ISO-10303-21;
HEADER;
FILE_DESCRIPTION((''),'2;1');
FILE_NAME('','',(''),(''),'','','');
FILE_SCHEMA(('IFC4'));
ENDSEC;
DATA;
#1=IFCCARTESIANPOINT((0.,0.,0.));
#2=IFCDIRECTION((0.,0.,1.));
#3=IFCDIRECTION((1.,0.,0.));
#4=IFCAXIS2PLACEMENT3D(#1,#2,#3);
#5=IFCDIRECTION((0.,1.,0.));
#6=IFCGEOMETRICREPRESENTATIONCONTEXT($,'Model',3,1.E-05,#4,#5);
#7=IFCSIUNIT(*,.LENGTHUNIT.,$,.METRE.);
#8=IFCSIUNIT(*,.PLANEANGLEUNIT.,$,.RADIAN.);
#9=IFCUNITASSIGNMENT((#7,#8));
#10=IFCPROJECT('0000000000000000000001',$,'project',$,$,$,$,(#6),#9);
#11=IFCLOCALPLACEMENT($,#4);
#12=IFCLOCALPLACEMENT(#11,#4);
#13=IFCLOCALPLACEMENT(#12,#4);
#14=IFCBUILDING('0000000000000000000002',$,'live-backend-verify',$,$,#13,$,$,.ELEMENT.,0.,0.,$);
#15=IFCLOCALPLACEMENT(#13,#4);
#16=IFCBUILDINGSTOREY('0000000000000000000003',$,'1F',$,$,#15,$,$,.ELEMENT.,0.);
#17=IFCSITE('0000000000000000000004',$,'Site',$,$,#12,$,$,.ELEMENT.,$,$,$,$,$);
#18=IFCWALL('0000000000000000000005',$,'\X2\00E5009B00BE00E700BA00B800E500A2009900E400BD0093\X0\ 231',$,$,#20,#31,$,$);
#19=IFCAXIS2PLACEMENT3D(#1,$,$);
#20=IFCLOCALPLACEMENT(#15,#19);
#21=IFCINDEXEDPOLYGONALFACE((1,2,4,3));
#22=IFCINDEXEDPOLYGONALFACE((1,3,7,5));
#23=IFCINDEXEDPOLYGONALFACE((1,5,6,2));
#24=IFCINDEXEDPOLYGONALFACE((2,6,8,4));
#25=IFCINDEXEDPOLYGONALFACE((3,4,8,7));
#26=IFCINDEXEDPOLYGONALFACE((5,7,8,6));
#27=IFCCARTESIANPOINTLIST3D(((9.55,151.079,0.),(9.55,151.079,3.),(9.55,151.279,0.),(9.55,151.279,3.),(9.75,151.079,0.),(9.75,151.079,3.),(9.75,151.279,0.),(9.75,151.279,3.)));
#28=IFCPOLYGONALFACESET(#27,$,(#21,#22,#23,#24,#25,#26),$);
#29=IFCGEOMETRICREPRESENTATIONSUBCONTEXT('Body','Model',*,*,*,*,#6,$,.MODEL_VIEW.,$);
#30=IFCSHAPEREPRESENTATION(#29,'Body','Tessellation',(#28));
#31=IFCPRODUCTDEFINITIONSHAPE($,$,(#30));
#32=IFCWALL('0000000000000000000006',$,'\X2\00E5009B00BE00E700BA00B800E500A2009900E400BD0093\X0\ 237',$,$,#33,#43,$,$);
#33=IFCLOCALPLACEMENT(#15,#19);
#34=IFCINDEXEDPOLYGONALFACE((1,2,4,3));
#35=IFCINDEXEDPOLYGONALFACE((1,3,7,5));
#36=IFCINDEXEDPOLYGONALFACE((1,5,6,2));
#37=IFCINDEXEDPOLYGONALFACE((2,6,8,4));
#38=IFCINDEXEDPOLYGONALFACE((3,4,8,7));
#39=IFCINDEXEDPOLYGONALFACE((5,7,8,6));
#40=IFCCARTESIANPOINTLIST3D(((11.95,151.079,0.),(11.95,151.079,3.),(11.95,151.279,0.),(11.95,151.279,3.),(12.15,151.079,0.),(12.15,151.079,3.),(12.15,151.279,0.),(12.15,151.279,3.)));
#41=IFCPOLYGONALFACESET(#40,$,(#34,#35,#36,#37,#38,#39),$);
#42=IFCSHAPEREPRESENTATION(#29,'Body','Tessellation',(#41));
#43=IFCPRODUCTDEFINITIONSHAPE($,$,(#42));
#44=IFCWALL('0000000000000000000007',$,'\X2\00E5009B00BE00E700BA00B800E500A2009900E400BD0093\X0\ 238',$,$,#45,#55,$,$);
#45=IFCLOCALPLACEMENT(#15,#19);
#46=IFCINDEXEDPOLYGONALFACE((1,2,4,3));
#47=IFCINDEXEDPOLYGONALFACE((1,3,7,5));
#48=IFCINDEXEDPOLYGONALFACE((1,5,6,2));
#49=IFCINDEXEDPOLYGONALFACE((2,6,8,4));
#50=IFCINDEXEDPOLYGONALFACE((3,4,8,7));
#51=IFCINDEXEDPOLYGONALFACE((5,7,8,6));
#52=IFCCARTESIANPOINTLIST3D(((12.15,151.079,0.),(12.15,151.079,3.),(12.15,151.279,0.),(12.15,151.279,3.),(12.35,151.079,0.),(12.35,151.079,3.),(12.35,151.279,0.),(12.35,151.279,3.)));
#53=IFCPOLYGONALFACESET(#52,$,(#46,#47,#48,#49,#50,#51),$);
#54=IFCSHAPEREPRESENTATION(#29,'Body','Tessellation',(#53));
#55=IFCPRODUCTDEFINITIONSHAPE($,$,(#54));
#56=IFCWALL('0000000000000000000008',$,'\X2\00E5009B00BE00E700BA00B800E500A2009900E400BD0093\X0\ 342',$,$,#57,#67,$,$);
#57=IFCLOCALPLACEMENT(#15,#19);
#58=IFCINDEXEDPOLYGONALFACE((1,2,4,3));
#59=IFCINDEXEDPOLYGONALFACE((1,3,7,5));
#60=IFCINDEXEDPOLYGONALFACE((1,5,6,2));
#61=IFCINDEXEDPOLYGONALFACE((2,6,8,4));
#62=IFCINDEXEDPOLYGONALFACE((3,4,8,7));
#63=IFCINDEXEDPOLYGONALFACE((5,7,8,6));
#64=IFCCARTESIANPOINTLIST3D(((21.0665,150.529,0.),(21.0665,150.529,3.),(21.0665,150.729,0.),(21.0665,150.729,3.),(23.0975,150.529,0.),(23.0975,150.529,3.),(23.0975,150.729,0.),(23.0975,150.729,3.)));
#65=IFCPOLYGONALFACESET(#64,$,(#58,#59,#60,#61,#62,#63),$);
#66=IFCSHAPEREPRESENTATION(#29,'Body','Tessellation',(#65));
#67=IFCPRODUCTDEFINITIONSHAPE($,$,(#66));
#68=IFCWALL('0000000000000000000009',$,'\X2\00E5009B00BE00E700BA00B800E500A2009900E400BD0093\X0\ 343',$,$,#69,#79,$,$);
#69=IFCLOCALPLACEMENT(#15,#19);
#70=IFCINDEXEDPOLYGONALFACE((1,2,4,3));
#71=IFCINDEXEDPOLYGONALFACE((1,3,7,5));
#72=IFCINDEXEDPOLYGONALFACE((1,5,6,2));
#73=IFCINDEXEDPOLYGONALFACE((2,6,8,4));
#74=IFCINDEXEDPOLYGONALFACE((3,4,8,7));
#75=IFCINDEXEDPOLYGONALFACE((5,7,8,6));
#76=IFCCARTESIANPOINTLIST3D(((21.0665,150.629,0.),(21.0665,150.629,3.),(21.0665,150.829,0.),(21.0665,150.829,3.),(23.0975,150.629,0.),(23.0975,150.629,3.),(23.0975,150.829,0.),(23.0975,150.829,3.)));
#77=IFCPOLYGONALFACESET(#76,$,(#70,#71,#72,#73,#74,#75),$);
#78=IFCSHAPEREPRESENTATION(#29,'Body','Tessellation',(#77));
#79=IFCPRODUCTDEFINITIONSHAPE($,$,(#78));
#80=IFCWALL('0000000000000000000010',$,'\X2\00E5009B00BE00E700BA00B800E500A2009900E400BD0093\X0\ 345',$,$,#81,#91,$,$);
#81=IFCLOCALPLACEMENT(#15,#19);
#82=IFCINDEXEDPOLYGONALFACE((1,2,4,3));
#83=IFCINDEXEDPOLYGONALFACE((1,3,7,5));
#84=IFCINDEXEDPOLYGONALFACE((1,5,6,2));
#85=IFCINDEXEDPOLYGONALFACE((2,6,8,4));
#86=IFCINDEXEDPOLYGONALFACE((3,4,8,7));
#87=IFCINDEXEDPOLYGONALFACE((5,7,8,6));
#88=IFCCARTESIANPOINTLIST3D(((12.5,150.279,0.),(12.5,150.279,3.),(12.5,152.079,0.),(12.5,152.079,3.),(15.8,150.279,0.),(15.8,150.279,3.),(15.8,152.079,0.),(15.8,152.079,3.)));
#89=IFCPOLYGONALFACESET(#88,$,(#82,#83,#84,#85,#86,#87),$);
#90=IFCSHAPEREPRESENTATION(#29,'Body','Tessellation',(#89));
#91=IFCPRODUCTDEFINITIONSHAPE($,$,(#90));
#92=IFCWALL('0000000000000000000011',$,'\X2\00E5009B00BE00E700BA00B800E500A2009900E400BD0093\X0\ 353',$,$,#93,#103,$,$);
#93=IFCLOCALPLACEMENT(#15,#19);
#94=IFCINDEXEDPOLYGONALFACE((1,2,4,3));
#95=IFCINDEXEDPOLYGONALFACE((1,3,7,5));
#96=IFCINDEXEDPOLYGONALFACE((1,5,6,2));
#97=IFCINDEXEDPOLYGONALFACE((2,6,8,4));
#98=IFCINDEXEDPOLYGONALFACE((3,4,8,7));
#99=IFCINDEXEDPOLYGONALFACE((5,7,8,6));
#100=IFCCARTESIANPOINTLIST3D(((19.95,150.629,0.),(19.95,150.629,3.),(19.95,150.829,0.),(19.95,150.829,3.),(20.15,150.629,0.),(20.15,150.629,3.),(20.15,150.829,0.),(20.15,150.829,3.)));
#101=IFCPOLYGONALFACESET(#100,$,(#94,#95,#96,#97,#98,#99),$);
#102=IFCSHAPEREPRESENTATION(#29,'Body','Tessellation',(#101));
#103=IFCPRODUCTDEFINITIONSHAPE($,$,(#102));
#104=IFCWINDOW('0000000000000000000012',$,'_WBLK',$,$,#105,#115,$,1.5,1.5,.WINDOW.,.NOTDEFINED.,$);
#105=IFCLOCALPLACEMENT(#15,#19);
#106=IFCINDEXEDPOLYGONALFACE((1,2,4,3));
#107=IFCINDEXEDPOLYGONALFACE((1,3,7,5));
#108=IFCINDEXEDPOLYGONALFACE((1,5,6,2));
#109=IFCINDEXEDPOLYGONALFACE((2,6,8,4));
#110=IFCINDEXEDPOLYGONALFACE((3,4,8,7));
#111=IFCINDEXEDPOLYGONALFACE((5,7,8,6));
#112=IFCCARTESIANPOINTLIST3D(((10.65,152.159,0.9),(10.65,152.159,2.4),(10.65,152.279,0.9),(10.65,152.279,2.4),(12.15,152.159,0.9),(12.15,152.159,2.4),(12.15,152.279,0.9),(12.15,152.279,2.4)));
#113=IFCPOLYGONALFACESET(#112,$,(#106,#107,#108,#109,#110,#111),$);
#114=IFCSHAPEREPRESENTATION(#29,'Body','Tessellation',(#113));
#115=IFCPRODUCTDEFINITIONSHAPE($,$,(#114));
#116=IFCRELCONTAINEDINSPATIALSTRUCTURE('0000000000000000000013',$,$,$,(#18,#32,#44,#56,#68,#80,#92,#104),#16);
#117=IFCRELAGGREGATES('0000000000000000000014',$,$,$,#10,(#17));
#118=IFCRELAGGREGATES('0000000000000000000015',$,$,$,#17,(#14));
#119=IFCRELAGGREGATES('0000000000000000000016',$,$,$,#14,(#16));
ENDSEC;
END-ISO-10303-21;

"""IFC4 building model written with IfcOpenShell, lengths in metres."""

from ifc_helpers import new_model, si_unit, direction, frame, frame_2d, origin_with_axes, place, context, subcontext, project, spatial, rectangle, extrude, element, save


model = new_model("IFC4")

# Units and contexts
model_context = context("Model", 3, precision=1e-05, world=origin_with_axes(), true_north=direction((0.0, 1.0, 0.0)))
body_context = subcontext(model_context, "Body", "Model", "MODEL_VIEW")
ifc_project = project(units=[si_unit("LENGTHUNIT", "METRE"), si_unit("PLANEANGLEUNIT", "RADIAN")], contexts=[model_context])

# Site, building, storey
placement = place(None, origin_with_axes())
site_placement = place(placement, origin_with_axes())
site = spatial("IfcSite", under=ifc_project, at=site_placement, Name="Site", CompositionType="ELEMENT")
building_placement = place(site_placement, origin_with_axes())
building = spatial("IfcBuilding", under=site, at=building_placement, Name="live-backend-verify", CompositionType="ELEMENT", ElevationOfRefHeight=0.0, ElevationOfTerrain=0.0)
storey_placement = place(building_placement, origin_with_axes())
storey = spatial("IfcBuildingStorey", under=building, at=storey_placement, Name="1F", CompositionType="ELEMENT", Elevation=0.0)

# Walls
for number, where, z_axis, x_axis, name in (
    (1, (9.65, 151.179, 0.0), (0.0, 0.0, 1.0), (1.0, 0.0, 0.0), "å\u009b¾çº¸å¢\u0099ä½\u0093 231"),
    (2, (12.05, 151.179, 0.0), (0.0, 0.0, 1.0), (1.0, 0.0, 0.0), "å\u009b¾çº¸å¢\u0099ä½\u0093 237"),
    (3, (12.25, 151.179, 0.0), (0.0, 0.0, 1.0), (-1.0, 0.0, 0.0), "å\u009b¾çº¸å¢\u0099ä½\u0093 238"),
):
    element("IfcWall", number, at=place(storey_placement, frame(where, z_axis=z_axis, x_axis=x_axis)), inside=storey, Name=name, context=body_context, shape_type="SweptSolid", body=[
        extrude(rectangle(XDim=0.2, YDim=0.2, at=frame_2d((0.0, 0.0), x_axis=(1.0, 0.0, 0.0))), frame((0.0, 0.0, 0.0), z_axis=(0.0, 0.0, 1.0)), (0.0, 0.0, 1.0), 3.0),
    ])
for number, where, z_axis, x_axis, name in (
    (4, (22.082, 150.629, 0.0), (0.0, 0.0, 1.0), (-1.0, 0.0, 0.0), "å\u009b¾çº¸å¢\u0099ä½\u0093 342"),
    (5, (22.082, 150.729, 0.0), (0.0, 0.0, 1.0), (-1.0, 0.0, 0.0), "å\u009b¾çº¸å¢\u0099ä½\u0093 343"),
):
    element("IfcWall", number, at=place(storey_placement, frame(where, z_axis=z_axis, x_axis=x_axis)), inside=storey, Name=name, context=body_context, shape_type="SweptSolid", body=[
        extrude(rectangle(XDim=2.031, YDim=0.2, at=frame_2d((0.0, 0.0), x_axis=(1.0, 0.0, 0.0))), frame((0.0, 0.0, 0.0), z_axis=(0.0, 0.0, 1.0)), (0.0, 0.0, 1.0), 3.0),
    ])
wall_1_placement = place(storey_placement, frame((14.15, 151.179, 0.0), z_axis=(0.0, 0.0, 1.0), x_axis=(1.0, 0.0, 0.0)))
element("IfcWall", 6, at=wall_1_placement, inside=storey, Name="å\u009b¾çº¸å¢\u0099ä½\u0093 345", context=body_context, shape_type="SweptSolid", body=[
    extrude(rectangle(XDim=3.3, YDim=1.8, at=frame_2d((0.0, 0.0), x_axis=(1.0, 0.0, 0.0))), frame((0.0, 0.0, 0.0), z_axis=(0.0, 0.0, 1.0)), (0.0, 0.0, 1.0), 3.0),
])
wall_2_placement = place(storey_placement, frame((20.05, 150.729, 0.0), z_axis=(0.0, 0.0, 1.0), x_axis=(-1.0, 0.0, 0.0)))
element("IfcWall", 7, at=wall_2_placement, inside=storey, Name="å\u009b¾çº¸å¢\u0099ä½\u0093 353", context=body_context, shape_type="SweptSolid", body=[
    extrude(rectangle(XDim=0.2, YDim=0.2, at=frame_2d((0.0, 0.0), x_axis=(1.0, 0.0, 0.0))), frame((0.0, 0.0, 0.0), z_axis=(0.0, 0.0, 1.0)), (0.0, 0.0, 1.0), 3.0),
])

# Window
window_placement = place(storey_placement, frame((11.4, 152.219, 0.9), z_axis=(0.0, 0.0, 1.0), x_axis=(1.0, 0.0, 0.0)))
element("IfcWindow", 8, at=window_placement, inside=storey, Name="_WBLK", OverallHeight=1.5, OverallWidth=1.5, PartitioningType="NOTDEFINED", PredefinedType="WINDOW", context=body_context, shape_type="SweptSolid", body=[
    extrude(rectangle(XDim=1.5, YDim=0.12, at=frame_2d((0.0, 0.0), x_axis=(1.0, 0.0, 0.0))), frame((0.0, 0.0, 0.0), z_axis=(0.0, 0.0, 1.0)), (0.0, 0.0, 1.0), 1.5),
])

save(model, "model.ifc")
